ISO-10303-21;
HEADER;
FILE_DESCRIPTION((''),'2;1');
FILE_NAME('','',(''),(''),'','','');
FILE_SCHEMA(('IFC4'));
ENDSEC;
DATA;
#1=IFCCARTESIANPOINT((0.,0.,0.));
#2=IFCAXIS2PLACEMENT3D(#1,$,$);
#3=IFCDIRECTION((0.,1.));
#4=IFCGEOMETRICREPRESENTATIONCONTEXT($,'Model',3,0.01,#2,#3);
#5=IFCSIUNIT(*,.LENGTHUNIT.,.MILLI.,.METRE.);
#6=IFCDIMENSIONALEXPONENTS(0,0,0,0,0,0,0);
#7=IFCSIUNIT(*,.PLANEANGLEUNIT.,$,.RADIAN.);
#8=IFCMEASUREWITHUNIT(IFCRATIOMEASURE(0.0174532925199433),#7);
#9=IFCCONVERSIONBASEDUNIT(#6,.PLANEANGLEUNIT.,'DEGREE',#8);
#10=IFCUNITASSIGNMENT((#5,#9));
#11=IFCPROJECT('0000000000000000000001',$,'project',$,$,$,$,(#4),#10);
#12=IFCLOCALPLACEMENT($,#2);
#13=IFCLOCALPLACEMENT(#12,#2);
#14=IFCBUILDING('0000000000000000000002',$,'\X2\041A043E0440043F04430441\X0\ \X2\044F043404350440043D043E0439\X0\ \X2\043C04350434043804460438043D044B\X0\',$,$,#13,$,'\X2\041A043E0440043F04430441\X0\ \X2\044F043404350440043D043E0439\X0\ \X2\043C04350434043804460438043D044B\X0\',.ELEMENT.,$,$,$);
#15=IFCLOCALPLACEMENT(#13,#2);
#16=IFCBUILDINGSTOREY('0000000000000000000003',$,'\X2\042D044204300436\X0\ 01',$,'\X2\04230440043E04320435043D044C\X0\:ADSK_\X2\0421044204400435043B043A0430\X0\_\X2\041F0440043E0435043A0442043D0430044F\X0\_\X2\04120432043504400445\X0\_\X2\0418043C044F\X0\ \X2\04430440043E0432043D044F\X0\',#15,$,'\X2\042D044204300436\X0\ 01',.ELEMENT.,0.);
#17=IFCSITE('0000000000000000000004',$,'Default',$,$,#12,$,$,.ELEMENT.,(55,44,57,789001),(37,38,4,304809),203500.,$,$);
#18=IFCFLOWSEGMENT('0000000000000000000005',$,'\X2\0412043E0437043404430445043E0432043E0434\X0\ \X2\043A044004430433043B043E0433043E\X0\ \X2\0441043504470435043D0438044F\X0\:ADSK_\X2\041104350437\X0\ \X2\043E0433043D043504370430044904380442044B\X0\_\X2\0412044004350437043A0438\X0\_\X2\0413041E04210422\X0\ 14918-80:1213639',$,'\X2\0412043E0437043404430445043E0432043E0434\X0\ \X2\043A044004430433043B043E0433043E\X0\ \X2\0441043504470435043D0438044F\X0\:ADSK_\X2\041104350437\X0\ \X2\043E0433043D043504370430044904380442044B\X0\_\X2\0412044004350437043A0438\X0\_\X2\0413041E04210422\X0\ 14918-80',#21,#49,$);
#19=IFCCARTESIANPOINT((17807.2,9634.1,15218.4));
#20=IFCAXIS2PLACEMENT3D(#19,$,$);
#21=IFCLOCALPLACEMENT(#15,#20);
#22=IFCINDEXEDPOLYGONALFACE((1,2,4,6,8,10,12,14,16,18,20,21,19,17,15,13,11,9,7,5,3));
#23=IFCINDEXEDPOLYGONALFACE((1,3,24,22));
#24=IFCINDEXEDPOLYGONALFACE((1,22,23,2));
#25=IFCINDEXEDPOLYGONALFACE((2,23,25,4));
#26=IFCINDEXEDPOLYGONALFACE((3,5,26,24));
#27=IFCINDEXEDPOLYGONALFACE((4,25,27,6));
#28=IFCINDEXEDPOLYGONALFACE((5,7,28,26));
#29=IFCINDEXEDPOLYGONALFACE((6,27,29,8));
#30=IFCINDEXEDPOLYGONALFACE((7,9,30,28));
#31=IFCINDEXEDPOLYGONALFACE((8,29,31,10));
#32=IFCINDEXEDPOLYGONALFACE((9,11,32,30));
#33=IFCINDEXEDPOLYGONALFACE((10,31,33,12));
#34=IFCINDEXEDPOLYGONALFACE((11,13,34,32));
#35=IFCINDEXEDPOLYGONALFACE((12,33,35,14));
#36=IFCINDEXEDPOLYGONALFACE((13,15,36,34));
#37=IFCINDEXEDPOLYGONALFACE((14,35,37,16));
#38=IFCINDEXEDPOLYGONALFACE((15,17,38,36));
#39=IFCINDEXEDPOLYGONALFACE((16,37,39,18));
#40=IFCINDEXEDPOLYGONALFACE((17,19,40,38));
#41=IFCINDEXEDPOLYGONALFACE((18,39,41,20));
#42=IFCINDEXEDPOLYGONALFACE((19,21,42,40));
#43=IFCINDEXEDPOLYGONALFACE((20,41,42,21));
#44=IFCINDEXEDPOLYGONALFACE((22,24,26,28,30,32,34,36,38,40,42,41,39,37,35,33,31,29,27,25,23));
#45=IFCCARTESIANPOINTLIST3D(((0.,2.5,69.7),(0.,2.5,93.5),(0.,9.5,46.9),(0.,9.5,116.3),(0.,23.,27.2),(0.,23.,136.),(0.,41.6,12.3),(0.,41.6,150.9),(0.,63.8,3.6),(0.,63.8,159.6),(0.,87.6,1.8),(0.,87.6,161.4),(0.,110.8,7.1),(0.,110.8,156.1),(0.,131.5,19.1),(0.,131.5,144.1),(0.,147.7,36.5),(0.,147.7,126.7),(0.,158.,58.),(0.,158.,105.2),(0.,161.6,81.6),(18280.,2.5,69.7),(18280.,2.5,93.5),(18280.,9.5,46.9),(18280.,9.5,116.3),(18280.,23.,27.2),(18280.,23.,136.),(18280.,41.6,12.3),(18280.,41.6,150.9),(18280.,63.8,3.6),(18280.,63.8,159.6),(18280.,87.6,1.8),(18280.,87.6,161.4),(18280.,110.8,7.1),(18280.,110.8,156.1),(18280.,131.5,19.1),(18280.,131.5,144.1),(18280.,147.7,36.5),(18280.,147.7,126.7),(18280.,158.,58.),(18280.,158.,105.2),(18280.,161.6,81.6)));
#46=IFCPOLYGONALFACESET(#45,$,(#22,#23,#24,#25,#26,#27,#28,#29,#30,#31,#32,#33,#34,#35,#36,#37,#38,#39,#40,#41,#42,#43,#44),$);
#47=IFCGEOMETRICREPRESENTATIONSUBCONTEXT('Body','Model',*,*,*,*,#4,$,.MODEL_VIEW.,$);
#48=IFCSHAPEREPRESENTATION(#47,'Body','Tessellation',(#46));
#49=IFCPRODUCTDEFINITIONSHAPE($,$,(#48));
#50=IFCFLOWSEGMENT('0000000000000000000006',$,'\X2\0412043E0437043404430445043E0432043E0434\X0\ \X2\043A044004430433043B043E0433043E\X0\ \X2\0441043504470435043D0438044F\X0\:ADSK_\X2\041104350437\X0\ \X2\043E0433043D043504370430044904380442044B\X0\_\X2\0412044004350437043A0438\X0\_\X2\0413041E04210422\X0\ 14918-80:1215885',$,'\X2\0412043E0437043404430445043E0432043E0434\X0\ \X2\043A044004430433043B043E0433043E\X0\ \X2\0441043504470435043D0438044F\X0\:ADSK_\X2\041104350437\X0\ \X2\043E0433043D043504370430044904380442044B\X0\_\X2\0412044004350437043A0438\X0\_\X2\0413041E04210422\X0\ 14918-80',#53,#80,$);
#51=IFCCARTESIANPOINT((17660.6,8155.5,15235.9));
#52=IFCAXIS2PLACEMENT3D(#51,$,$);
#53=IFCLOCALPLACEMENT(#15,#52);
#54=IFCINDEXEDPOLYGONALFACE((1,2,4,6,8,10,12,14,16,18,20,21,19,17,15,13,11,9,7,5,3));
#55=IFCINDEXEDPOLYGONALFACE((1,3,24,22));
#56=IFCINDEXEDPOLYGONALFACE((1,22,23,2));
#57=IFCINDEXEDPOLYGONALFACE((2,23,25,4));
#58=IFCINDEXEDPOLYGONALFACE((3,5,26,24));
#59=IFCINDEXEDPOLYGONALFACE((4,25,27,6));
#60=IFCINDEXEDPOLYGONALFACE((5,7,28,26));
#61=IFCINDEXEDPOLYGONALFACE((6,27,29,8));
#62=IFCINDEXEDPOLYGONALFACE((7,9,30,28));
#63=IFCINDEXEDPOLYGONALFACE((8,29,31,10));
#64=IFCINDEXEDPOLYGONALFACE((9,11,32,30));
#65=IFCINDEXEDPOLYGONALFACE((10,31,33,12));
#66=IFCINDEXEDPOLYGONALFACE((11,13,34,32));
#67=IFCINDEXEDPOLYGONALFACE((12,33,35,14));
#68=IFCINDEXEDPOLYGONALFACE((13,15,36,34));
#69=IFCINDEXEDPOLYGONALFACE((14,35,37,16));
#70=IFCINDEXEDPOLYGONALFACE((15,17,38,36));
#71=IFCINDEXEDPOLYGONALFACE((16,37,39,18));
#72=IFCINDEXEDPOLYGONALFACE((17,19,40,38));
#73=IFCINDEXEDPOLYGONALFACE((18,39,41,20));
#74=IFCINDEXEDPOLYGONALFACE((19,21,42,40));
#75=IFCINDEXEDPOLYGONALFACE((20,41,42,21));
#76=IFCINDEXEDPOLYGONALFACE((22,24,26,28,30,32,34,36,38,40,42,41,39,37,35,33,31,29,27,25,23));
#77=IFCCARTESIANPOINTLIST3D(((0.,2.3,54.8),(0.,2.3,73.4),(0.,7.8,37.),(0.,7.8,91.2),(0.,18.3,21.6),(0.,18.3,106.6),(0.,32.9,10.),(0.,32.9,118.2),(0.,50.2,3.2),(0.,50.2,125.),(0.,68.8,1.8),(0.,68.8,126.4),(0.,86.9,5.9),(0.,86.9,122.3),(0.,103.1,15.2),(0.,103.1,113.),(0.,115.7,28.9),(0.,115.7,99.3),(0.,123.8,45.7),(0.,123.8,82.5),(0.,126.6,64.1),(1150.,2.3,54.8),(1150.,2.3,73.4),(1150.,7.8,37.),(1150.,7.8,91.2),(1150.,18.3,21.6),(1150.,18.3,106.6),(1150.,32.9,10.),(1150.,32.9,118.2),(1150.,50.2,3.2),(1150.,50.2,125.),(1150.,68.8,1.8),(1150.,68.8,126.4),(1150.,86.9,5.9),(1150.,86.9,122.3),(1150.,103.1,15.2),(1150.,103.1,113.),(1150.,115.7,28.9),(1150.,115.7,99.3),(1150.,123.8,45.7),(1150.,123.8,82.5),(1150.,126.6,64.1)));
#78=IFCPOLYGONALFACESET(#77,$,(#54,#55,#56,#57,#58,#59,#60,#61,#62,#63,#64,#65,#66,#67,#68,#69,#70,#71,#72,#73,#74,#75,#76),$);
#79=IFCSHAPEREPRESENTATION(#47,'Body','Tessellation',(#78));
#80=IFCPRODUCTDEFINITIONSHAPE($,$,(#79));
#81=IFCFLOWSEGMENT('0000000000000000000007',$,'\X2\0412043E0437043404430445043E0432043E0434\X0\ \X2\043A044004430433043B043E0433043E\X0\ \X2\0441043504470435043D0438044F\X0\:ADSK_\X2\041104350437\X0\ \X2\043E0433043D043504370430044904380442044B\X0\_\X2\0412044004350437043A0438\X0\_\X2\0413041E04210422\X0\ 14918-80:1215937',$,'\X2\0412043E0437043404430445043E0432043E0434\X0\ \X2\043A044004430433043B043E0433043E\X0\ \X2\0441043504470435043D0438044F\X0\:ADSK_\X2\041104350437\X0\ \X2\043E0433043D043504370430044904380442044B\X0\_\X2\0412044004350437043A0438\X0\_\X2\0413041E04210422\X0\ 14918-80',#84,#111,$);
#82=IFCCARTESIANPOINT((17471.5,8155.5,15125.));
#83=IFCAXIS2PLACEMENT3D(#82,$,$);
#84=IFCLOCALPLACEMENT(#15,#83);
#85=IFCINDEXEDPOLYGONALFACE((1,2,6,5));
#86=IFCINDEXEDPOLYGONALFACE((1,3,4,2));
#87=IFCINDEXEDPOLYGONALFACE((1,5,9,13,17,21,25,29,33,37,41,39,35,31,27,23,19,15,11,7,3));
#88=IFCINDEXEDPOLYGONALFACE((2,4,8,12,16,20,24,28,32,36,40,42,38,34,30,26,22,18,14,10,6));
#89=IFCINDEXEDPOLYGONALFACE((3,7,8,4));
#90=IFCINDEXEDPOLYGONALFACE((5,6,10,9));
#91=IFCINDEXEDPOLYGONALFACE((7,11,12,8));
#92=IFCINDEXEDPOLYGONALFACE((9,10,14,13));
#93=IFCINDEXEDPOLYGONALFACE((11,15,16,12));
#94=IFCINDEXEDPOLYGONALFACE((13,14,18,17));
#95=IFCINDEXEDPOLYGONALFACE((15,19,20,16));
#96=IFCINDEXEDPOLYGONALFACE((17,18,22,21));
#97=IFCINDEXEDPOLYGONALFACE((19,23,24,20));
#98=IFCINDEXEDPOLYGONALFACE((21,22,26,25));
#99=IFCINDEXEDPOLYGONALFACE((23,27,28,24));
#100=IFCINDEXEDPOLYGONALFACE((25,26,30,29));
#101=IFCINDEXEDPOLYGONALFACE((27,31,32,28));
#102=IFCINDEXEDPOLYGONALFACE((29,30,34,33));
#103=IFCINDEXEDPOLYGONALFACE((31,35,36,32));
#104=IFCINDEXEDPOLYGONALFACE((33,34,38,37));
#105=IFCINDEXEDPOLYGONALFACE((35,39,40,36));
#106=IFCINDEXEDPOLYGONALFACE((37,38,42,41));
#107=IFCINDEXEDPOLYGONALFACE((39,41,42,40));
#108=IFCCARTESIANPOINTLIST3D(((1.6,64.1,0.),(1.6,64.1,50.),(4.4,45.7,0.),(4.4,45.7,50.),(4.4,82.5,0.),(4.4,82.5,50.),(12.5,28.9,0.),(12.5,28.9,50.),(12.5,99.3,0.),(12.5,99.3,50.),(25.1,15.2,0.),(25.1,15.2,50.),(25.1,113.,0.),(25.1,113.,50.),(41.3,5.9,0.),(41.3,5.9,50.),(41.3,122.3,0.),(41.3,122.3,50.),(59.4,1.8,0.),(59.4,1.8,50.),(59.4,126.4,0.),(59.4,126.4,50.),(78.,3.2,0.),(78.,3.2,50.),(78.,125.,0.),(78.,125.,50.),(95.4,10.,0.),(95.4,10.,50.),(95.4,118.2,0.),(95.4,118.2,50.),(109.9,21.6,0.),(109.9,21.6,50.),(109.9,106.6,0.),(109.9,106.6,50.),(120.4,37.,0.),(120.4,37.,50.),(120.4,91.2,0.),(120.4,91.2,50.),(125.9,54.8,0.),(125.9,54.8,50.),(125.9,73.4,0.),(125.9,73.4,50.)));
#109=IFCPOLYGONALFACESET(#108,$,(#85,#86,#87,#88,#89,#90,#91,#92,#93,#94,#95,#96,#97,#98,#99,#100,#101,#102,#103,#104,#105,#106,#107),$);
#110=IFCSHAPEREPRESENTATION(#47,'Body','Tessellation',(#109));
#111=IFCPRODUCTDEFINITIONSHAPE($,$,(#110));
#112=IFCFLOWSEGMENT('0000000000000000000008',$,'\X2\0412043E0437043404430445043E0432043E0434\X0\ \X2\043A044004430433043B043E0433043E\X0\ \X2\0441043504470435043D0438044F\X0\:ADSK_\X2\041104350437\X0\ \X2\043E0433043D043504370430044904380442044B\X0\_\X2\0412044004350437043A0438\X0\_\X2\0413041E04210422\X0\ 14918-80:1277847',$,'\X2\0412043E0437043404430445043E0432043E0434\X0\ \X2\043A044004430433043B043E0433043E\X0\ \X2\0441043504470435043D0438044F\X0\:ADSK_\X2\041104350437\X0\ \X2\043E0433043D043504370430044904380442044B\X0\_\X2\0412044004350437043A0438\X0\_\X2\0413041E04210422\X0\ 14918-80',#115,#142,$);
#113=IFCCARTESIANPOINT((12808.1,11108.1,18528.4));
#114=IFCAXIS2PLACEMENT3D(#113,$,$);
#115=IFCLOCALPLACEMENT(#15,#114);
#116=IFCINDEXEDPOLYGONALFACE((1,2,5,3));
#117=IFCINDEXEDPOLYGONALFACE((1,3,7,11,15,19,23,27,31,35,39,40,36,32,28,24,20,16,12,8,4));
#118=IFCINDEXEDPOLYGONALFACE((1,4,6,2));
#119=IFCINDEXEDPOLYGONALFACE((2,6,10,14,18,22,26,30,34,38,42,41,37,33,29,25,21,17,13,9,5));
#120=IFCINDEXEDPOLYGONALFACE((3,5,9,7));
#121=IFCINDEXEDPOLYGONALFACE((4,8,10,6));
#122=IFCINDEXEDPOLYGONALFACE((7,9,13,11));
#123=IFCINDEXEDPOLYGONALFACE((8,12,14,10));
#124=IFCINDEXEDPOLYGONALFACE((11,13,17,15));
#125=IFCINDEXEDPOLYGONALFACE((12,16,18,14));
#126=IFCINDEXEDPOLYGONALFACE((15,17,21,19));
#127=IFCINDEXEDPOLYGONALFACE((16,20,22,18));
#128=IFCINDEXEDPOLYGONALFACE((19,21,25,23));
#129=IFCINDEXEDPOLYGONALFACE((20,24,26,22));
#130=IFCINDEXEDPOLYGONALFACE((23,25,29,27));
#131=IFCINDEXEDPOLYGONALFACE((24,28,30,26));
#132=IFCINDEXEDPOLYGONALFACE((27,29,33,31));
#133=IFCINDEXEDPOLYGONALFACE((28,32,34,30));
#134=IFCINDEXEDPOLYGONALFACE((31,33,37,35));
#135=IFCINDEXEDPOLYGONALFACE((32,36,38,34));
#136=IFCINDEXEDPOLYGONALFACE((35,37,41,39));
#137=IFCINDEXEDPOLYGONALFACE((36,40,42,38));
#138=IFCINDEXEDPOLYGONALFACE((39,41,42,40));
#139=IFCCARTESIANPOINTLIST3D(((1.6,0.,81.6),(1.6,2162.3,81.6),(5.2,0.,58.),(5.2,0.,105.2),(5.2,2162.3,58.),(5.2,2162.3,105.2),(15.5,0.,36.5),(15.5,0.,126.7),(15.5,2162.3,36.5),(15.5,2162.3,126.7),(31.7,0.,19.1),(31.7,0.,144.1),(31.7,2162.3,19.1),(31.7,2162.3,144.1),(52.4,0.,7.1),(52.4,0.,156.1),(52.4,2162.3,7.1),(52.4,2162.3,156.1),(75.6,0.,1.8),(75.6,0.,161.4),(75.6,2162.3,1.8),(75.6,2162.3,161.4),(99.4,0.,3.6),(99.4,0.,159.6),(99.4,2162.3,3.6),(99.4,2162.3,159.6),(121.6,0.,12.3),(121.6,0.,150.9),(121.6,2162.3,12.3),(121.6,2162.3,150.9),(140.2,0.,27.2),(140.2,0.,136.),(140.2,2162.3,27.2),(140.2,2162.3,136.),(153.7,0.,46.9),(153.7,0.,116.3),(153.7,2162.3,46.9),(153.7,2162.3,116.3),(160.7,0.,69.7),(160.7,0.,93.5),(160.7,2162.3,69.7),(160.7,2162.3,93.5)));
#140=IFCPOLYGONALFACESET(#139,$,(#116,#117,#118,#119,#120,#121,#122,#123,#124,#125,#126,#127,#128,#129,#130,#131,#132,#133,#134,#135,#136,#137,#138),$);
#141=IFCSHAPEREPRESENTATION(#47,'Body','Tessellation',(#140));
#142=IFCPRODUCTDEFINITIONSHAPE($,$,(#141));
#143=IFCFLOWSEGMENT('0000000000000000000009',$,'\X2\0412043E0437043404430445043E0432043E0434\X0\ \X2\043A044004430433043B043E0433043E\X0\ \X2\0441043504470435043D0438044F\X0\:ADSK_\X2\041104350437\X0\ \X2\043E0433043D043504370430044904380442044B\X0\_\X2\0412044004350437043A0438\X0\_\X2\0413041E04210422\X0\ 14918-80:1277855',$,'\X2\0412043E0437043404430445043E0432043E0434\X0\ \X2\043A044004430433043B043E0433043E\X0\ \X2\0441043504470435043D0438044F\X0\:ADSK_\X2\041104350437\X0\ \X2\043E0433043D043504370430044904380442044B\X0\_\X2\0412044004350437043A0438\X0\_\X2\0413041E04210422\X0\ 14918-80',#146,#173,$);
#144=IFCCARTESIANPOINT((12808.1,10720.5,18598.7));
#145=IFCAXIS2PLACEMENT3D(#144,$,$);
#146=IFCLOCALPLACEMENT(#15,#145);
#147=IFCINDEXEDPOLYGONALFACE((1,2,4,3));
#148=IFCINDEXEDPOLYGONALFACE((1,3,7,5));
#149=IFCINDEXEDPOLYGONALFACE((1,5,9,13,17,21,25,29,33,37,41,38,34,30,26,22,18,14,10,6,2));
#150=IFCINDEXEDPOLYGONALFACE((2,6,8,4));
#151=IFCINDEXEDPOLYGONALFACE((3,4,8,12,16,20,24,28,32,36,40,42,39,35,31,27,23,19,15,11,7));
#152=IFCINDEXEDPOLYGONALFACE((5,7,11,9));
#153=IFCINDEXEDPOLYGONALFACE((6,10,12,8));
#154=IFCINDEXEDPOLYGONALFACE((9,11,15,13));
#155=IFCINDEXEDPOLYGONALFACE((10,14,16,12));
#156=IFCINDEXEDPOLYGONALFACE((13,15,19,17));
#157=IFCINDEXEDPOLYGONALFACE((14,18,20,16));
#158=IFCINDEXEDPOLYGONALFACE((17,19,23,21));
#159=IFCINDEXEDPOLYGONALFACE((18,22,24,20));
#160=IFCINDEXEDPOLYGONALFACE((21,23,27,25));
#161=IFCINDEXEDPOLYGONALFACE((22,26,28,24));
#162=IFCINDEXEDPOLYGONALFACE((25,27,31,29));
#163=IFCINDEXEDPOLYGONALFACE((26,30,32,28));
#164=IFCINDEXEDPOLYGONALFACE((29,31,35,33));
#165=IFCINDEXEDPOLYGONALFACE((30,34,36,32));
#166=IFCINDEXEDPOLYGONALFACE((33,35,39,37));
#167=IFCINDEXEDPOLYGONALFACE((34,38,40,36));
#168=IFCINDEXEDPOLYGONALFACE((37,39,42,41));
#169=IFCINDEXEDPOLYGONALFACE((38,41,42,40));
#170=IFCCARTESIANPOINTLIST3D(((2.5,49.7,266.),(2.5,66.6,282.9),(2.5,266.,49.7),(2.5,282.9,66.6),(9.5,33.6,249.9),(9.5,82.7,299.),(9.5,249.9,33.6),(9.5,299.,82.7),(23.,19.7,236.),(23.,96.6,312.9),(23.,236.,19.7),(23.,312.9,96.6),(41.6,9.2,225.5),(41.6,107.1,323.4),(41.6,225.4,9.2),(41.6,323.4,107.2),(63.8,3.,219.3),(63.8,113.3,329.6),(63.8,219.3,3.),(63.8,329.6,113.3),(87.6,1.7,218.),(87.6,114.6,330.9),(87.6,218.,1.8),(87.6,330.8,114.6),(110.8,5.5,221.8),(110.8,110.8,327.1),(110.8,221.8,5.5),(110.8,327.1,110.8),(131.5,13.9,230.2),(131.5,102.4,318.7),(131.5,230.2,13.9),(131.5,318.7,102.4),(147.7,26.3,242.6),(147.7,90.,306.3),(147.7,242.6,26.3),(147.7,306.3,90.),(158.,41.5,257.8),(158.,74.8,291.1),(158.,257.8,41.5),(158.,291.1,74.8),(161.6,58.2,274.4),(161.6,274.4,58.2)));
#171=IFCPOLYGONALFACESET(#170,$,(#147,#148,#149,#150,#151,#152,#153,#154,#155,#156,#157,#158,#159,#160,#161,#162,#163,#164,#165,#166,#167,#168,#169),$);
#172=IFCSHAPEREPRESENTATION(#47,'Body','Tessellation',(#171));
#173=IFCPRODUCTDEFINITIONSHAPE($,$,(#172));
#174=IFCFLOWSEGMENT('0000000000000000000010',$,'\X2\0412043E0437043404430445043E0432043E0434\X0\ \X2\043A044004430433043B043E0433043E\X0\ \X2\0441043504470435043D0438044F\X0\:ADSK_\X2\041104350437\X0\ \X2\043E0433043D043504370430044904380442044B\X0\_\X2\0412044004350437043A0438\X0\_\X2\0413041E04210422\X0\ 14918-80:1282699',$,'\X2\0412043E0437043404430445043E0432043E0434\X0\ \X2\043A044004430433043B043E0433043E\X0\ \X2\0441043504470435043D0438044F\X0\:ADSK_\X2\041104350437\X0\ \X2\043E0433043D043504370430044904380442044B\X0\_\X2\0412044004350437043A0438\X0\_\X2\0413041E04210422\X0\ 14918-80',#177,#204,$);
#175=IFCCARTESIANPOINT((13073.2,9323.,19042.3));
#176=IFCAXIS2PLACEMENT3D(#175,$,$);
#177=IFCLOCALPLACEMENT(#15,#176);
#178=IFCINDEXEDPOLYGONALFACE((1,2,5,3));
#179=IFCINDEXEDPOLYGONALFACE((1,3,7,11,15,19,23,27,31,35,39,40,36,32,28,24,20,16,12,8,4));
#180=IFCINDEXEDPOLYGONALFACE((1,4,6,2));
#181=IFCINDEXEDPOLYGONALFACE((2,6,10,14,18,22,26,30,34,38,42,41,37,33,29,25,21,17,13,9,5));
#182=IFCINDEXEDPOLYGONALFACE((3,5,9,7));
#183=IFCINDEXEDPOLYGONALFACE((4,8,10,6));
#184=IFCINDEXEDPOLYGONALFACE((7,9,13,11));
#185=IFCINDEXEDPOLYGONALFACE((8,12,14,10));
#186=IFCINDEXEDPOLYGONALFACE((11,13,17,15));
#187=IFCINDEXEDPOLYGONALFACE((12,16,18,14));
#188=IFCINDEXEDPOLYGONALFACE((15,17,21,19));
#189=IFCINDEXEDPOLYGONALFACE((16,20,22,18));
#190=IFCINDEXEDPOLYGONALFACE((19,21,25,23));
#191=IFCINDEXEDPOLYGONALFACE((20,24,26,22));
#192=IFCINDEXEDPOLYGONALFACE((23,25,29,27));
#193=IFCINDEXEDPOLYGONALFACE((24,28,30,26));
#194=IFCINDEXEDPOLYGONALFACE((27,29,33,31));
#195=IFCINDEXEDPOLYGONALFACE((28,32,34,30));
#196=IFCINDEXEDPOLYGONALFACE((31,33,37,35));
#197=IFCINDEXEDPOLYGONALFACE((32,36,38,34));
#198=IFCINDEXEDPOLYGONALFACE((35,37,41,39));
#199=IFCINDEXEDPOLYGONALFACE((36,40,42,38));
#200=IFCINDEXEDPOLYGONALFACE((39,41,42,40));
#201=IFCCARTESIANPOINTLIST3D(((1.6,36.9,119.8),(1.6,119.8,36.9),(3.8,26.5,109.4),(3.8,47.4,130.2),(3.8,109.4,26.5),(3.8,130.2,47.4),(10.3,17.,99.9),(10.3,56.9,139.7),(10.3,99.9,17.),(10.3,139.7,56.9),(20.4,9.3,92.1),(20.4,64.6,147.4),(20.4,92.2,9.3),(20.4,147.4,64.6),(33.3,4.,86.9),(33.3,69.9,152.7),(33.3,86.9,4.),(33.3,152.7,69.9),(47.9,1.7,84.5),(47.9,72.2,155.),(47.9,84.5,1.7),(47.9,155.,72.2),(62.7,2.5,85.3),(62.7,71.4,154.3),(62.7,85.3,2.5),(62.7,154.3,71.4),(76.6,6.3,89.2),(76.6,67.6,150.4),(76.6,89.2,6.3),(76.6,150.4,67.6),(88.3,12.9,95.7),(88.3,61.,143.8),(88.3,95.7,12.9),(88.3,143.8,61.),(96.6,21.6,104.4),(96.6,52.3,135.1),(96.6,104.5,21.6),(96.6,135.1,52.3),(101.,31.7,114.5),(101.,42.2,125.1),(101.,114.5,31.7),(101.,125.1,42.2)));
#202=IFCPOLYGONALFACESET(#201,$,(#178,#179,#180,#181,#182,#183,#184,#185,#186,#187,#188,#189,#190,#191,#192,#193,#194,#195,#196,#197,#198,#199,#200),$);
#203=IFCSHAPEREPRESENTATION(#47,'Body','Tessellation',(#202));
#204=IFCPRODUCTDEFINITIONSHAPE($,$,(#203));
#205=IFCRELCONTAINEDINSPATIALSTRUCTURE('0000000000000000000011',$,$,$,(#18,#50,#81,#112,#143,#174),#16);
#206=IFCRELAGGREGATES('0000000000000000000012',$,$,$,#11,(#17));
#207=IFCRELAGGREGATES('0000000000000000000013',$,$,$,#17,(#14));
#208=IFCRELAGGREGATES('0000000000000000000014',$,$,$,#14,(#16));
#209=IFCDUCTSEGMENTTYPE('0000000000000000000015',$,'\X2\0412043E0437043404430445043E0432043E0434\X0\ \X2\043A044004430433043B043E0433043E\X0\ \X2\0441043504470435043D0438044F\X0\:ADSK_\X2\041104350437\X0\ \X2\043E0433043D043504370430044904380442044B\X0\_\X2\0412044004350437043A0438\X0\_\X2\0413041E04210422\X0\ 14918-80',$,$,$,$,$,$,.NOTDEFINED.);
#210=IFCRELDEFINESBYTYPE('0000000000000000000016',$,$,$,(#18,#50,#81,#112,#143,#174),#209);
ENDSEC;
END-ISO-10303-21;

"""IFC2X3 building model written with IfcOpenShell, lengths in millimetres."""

from ifc_helpers import new_model, entity, si_unit, converted_unit, direction, frame, origin, origin_2d_with_axis, place, context, subcontext, project, spatial, circle, extrude, type_object, element, save


model = new_model("IFC2X3")

# Units and contexts
model_context = context("Model", 3, precision=0.01, world=origin(), true_north=direction((0.0, 1.0)))
body_context = subcontext(model_context, "Body", "Model", "MODEL_VIEW")
ifc_project = project(units=[si_unit("LENGTHUNIT", "METRE", prefix="MILLI"), converted_unit("PLANEANGLEUNIT", "DEGREE", entity("IfcRatioMeasure", 0.0174532925199433), si_unit("PLANEANGLEUNIT", "RADIAN"), dimensions=[0, 0, 0, 0, 0, 0, 0])], contexts=[model_context])

# Site, building, storey
site_placement = place(None, origin())
site = spatial("IfcSite", under=ifc_project, at=site_placement, Name="Default", CompositionType="ELEMENT", RefLatitude=(55, 44, 57, 789001), RefLongitude=(37, 38, 4, 304809), RefElevation=203500.0)
building_placement = place(site_placement, origin())
building = spatial("IfcBuilding", under=site, at=building_placement, Name="Корпус ядерной медицины", LongName="Корпус ядерной медицины", CompositionType="ELEMENT")
storey_placement = place(building_placement, origin())
storey = spatial("IfcBuildingStorey", under=building, at=storey_placement, Name="Этаж 01", ObjectType="Уровень:ADSK_Стрелка_Проектная_Вверх_Имя уровня", LongName="Этаж 01", CompositionType="ELEMENT", Elevation=0.0)

# Flow segments
duct_segment_type_1 = type_object("IfcDuctSegmentType", Name="Воздуховод круглого сечения:ADSK_Без огнезащиты_Врезки_ГОСТ 14918-80", PredefinedType="NOTDEFINED")
flow_segment_1_placement = place(storey_placement, frame((17807.2, 9634.1, 15218.4)))
element("IfcFlowSegment", 1, at=flow_segment_1_placement, inside=storey, type_object=duct_segment_type_1, Name="Воздуховод круглого сечения:ADSK_Без огнезащиты_Врезки_ГОСТ 14918-80:1213639", ObjectType="Воздуховод круглого сечения:ADSK_Без огнезащиты_Врезки_ГОСТ 14918-80", context=body_context, shape_type="SweptSolid", body=[
    extrude(circle(Radius=80.0, at=origin_2d_with_axis()), frame((0.0, 81.6, 81.6), z_axis=(1.0, 0.0, 0.0), x_axis=(0.0, 1.0, 0.0)), (0.0, 0.0, 1.0), 18280.0),
])
flow_segment_2_placement = place(storey_placement, frame((17660.6, 8155.5, 15235.9)))
element("IfcFlowSegment", 2, at=flow_segment_2_placement, inside=storey, type_object=duct_segment_type_1, Name="Воздуховод круглого сечения:ADSK_Без огнезащиты_Врезки_ГОСТ 14918-80:1215885", ObjectType="Воздуховод круглого сечения:ADSK_Без огнезащиты_Врезки_ГОСТ 14918-80", context=body_context, shape_type="SweptSolid", body=[
    extrude(circle(Radius=62.5, at=origin_2d_with_axis()), frame((0.0, 64.1, 64.1), z_axis=(1.0, 0.0, 0.0), x_axis=(0.0, 1.0, 0.0)), (0.0, 0.0, 1.0), 1150.0),
])
flow_segment_3_placement = place(storey_placement, frame((17471.5, 8155.5, 15125.0)))
element("IfcFlowSegment", 3, at=flow_segment_3_placement, inside=storey, type_object=duct_segment_type_1, Name="Воздуховод круглого сечения:ADSK_Без огнезащиты_Врезки_ГОСТ 14918-80:1215937", ObjectType="Воздуховод круглого сечения:ADSK_Без огнезащиты_Врезки_ГОСТ 14918-80", context=body_context, shape_type="SweptSolid", body=[
    extrude(circle(Radius=62.5, at=origin_2d_with_axis()), frame((64.1, 64.1, 0.0), z_axis=(0.0, 0.0, 1.0), x_axis=(-1.0, 0.0, 0.0)), (0.0, 0.0, 1.0), 50.0),
])
flow_segment_4_placement = place(storey_placement, frame((12808.1, 11108.1, 18528.4)))
element("IfcFlowSegment", 4, at=flow_segment_4_placement, inside=storey, type_object=duct_segment_type_1, Name="Воздуховод круглого сечения:ADSK_Без огнезащиты_Врезки_ГОСТ 14918-80:1277847", ObjectType="Воздуховод круглого сечения:ADSK_Без огнезащиты_Врезки_ГОСТ 14918-80", context=body_context, shape_type="SweptSolid", body=[
    extrude(circle(Radius=80.0, at=origin_2d_with_axis()), frame((81.6, 0.0, 81.6), z_axis=(0.0, 1.0, 0.0), x_axis=(-1.0, 0.0, 0.0)), (0.0, 0.0, 1.0), 2162.3),
])
flow_segment_5_placement = place(storey_placement, frame((12808.1, 10720.5, 18598.7)))
element("IfcFlowSegment", 5, at=flow_segment_5_placement, inside=storey, type_object=duct_segment_type_1, Name="Воздуховод круглого сечения:ADSK_Без огнезащиты_Врезки_ГОСТ 14918-80:1277855", ObjectType="Воздуховод круглого сечения:ADSK_Без огнезащиты_Врезки_ГОСТ 14918-80", context=body_context, shape_type="SweptSolid", body=[
    extrude(circle(Radius=80.0, at=origin_2d_with_axis()), frame((81.6, 58.2, 274.4), z_axis=(0.0, 0.707107, -0.707107), x_axis=(1.0, 0.0, 0.0)), (0.0, 0.0, 1.0), 305.9),
])
flow_segment_6_placement = place(storey_placement, frame((13073.2, 9323.0, 19042.3)))
element("IfcFlowSegment", 6, at=flow_segment_6_placement, inside=storey, type_object=duct_segment_type_1, Name="Воздуховод круглого сечения:ADSK_Без огнезащиты_Врезки_ГОСТ 14918-80:1282699", ObjectType="Воздуховод круглого сечения:ADSK_Без огнезащиты_Врезки_ГОСТ 14918-80", context=body_context, shape_type="SweptSolid", body=[
    extrude(circle(Radius=50.0, at=origin_2d_with_axis()), frame((51.6, 37.0, 119.8), z_axis=(0.0, 0.707107, -0.707107), x_axis=(-1.0, 0.0, 0.0)), (0.0, 0.0, 1.0), 117.2),
])

save(model, "model.ifc")
